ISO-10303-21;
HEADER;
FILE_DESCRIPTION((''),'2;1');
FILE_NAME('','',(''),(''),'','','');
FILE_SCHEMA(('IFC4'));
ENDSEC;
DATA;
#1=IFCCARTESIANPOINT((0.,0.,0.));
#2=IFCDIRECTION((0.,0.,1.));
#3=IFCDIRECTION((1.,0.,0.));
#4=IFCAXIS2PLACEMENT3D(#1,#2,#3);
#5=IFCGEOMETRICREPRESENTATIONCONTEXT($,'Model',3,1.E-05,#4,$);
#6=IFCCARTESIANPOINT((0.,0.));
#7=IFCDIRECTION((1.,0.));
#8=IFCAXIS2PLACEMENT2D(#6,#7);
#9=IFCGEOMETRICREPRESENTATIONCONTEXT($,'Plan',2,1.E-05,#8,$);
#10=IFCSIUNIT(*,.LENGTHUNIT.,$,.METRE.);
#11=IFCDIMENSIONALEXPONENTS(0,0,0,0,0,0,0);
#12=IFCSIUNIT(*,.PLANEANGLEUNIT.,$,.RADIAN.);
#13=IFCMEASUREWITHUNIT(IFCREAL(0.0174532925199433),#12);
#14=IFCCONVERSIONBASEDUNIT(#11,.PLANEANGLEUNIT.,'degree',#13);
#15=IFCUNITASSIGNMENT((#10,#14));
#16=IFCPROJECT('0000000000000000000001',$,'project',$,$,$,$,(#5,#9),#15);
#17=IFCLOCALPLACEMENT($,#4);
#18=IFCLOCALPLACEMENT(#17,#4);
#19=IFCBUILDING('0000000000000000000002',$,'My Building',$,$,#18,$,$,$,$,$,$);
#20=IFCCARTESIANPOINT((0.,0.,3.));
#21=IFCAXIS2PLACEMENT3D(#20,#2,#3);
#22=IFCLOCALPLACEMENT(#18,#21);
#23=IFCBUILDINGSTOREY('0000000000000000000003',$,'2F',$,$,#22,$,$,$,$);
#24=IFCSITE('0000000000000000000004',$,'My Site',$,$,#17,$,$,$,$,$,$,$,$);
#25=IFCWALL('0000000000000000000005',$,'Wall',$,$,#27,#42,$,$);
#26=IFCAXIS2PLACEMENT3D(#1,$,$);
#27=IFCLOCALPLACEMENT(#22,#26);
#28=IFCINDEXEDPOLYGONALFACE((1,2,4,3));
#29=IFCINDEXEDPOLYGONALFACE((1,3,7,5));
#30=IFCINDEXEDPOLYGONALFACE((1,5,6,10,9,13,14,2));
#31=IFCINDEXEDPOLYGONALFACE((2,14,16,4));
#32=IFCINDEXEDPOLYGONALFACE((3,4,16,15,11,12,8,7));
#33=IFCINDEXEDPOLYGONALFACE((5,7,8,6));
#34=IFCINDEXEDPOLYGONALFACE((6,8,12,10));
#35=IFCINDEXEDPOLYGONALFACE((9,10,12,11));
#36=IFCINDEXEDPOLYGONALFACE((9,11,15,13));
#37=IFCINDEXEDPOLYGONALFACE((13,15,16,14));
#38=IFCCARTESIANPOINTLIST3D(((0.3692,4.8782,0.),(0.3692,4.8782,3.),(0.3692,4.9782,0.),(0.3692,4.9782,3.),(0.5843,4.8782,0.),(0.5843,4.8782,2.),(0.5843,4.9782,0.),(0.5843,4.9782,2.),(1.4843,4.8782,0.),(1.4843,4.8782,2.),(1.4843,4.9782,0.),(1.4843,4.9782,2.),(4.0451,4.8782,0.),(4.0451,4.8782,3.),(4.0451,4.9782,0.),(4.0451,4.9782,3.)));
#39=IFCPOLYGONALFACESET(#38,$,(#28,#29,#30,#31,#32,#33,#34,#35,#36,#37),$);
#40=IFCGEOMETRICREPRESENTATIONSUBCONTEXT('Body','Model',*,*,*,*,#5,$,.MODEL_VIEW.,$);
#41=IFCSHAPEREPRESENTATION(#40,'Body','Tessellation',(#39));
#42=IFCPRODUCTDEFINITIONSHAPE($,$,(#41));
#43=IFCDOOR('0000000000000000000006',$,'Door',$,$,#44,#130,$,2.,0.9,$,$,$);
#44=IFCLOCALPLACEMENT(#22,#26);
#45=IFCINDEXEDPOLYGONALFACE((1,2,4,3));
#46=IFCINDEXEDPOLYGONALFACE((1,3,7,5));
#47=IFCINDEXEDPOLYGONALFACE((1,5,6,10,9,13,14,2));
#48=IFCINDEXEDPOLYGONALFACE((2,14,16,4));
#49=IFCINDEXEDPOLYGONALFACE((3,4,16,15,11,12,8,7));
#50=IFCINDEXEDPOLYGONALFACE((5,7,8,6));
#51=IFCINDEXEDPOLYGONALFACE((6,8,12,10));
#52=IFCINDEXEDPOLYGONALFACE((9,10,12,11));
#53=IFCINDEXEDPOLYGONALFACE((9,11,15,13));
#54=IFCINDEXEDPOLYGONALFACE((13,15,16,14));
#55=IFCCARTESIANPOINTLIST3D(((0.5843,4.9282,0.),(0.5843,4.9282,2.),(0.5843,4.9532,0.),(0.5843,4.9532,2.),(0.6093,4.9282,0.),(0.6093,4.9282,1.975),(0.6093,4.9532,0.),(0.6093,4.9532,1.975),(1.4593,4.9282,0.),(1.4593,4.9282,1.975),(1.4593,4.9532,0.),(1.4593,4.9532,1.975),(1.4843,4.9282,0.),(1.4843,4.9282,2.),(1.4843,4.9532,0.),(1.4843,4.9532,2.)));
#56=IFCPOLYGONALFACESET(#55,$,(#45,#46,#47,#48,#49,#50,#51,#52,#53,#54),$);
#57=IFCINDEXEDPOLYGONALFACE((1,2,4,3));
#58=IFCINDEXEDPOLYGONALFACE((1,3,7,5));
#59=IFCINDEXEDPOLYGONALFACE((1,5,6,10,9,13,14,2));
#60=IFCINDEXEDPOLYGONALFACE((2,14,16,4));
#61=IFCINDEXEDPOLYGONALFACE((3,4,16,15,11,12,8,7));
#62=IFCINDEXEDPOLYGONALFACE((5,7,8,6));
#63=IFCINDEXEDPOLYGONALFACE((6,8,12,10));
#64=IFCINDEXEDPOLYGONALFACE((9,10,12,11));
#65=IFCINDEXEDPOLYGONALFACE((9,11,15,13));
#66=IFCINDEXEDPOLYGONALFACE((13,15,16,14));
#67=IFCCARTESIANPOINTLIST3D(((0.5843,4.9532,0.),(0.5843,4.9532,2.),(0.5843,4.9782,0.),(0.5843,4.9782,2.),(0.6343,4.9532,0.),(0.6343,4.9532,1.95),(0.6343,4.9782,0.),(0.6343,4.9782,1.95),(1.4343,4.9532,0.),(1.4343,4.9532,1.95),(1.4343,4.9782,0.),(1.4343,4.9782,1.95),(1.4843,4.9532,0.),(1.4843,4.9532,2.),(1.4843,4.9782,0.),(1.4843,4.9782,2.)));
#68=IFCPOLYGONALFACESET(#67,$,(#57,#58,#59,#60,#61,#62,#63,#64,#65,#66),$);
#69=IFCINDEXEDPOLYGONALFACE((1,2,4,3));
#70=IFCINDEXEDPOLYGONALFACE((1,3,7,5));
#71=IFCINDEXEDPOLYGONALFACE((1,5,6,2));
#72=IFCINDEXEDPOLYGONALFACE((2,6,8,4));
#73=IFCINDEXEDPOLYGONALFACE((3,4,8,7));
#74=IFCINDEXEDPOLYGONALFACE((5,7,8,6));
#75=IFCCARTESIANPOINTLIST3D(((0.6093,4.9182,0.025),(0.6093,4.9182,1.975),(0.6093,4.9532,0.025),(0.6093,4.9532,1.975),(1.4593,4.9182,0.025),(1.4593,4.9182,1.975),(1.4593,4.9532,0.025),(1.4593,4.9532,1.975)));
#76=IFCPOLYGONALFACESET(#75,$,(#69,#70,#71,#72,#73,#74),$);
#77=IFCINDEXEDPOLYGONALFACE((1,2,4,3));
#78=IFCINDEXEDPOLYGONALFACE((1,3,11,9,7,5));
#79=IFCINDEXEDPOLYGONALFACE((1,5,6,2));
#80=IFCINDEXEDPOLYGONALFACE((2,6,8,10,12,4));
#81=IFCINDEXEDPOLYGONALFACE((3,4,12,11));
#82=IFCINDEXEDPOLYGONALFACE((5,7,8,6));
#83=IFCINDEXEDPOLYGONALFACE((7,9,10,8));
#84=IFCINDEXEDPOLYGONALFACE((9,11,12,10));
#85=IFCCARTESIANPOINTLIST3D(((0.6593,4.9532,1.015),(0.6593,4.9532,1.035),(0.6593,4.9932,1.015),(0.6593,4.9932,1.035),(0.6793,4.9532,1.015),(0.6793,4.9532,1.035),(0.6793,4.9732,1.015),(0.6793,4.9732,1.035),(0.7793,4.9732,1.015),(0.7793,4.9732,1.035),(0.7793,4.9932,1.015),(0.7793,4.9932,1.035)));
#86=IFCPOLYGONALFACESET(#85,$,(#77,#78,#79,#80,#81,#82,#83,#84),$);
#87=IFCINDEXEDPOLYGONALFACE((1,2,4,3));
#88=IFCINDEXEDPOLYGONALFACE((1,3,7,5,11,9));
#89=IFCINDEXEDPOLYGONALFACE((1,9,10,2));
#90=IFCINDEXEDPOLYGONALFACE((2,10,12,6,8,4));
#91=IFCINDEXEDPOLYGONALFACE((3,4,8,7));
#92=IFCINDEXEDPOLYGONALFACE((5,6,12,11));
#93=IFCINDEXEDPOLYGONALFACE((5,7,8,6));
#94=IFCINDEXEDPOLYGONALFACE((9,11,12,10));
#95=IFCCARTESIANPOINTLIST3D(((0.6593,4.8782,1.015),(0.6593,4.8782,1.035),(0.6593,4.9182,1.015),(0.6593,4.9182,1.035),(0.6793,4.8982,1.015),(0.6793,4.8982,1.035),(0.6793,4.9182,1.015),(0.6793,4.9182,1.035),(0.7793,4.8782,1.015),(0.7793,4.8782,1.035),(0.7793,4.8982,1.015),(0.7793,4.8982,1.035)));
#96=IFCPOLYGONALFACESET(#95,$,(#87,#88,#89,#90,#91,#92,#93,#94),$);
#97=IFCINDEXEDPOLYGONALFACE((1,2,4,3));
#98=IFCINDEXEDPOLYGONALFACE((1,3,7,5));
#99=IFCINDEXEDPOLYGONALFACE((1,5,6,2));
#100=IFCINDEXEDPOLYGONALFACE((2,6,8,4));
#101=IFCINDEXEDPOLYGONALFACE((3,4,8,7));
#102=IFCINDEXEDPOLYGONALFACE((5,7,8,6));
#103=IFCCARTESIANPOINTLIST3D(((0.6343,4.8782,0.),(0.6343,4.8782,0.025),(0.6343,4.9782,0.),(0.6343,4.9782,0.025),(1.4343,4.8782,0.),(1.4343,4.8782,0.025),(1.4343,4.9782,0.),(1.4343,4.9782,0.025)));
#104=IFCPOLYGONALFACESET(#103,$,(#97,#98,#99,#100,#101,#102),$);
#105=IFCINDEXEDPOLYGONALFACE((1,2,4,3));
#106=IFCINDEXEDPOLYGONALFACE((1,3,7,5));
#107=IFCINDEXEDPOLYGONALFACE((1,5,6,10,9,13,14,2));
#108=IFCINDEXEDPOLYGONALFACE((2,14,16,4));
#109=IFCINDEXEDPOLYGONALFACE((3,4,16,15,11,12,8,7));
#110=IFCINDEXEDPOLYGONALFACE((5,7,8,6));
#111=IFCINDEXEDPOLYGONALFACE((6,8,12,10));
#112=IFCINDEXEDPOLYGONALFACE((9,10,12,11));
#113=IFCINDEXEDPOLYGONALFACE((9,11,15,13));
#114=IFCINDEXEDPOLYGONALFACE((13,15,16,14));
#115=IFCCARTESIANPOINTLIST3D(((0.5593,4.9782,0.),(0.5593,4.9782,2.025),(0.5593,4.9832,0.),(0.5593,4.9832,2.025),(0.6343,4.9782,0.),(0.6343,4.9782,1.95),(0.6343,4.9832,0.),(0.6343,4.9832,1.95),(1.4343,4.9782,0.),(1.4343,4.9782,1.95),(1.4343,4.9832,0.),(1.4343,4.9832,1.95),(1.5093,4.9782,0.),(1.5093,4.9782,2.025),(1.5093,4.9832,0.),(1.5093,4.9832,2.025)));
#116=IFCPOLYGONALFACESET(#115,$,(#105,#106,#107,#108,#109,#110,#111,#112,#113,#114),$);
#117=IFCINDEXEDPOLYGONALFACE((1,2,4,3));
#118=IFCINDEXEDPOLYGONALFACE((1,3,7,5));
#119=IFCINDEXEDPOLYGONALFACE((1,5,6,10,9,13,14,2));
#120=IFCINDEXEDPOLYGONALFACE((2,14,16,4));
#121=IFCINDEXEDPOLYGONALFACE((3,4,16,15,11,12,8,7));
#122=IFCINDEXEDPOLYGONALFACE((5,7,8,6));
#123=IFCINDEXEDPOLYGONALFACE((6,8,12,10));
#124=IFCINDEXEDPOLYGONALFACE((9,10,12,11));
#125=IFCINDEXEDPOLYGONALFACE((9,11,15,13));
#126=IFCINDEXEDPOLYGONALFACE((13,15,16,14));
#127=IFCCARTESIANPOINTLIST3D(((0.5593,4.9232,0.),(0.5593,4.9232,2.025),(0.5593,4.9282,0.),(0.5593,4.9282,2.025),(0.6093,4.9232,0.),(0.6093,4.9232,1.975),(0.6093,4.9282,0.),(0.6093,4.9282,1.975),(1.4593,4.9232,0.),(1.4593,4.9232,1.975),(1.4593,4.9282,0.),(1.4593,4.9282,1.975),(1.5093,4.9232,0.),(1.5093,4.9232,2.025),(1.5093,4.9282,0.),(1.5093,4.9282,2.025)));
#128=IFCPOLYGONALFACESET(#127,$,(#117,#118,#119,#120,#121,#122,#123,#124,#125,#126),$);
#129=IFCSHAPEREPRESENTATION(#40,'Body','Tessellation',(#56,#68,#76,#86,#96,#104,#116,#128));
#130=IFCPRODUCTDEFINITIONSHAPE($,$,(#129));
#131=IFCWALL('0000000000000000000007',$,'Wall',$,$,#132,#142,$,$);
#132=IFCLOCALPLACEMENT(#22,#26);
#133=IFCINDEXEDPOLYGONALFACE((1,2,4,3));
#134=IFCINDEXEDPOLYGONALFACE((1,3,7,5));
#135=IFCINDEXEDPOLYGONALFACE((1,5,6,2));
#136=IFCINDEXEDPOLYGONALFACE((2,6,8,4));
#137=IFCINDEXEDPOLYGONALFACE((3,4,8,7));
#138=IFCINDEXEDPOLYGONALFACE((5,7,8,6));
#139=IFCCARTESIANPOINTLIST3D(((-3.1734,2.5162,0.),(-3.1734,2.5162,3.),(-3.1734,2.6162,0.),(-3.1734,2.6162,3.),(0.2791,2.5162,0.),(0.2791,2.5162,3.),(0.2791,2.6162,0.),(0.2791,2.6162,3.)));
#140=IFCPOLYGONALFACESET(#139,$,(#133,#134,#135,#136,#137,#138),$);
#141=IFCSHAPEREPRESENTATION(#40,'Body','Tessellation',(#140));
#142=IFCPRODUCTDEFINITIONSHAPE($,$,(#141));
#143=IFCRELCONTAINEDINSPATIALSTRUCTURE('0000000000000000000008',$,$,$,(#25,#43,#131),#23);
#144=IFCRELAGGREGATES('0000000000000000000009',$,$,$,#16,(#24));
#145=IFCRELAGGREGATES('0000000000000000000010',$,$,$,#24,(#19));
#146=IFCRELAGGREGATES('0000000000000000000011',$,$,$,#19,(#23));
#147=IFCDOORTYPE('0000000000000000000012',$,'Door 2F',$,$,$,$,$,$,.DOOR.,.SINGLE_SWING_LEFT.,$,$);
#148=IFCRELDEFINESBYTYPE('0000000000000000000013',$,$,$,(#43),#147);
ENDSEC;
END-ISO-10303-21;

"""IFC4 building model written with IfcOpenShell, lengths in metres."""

from ifc_helpers import new_model, entity, si_unit, converted_unit, frame, origin_with_axes, origin_2d_with_axis, place, context, subcontext, project, spatial, line, indexed_curve, outline, extrude, shape, source, transform, mapped, type_object, type_shapes, element, fill, save


model = new_model("IFC4")

# Units and contexts
model_context = context("Model", 3, precision=1e-05, world=origin_with_axes())
plan_context = context("Plan", 2, precision=1e-05, world=origin_2d_with_axis())
body_context_1 = subcontext(model_context, "Body", "Model", "MODEL_VIEW")
body_context_2 = subcontext(plan_context, "Body", "Plan", "PLAN_VIEW")
ifc_project = project(units=[si_unit("LENGTHUNIT", "METRE"), converted_unit("PLANEANGLEUNIT", "degree", entity("IfcReal", 0.0174532925199433), si_unit("PLANEANGLEUNIT", "RADIAN"), dimensions=[0, 0, 0, 0, 0, 0, 0])], contexts=[model_context, plan_context])

# Site, building, storey
site_placement = place(None, origin_with_axes())
site = spatial("IfcSite", under=ifc_project, at=site_placement, Name="My Site")
building_placement = place(site_placement, origin_with_axes())
building = spatial("IfcBuilding", under=site, at=building_placement, Name="My Building")
storey_placement = place(building_placement, frame((0.0, 0.0, 3.0), z_axis=(0.0, 0.0, 1.0), x_axis=(1.0, 0.0, 0.0)))
storey = spatial("IfcBuildingStorey", under=building, at=storey_placement, Name="2F")

# Shared definitions
shared_shape_1 = source(origin_with_axes(), body_context_1, "Body", "SweptSolid", [
    extrude(outline(indexed_curve([(0.0, 0.0), (0.9, 0.0), (0.9, 2.0), (0.0, 2.0)], segments=[line(1, 2, 3, 4, 1)])), frame((0.0, -0.6, 0.0), z_axis=(0.0, -1.0, 0.0), x_axis=(1.0, 0.0, 0.0)), (0.0, 0.0, -1.0), 1.2),
])
door_type = type_object("IfcDoorType", Name="Door 2F", OperationType="SINGLE_SWING_LEFT", PredefinedType="DOOR")
shared_shape_2 = source(origin_with_axes(), body_context_1, "Body", "SweptSolid", [
    extrude(outline(indexed_curve([(0.0, 0.0), (0.0, 2.0), (0.9, 2.0), (0.9, 0.0), (0.875, 0.0), (0.875, 1.975), (0.025, 1.975), (0.025, 0.0)], segments=[line(1, 2, 3, 4, 5, 6, 7, 8, 1)])), frame((0.0, 0.025, 0.0), z_axis=(0.0, -1.0, 0.0), x_axis=(1.0, 0.0, 0.0)), (0.0, 0.0, -1.0), 0.025),
    extrude(outline(indexed_curve([(0.0, 0.0), (0.0, 2.0), (0.9, 2.0), (0.9, 0.0), (0.85, 0.0), (0.85, 1.95), (0.05, 1.95), (0.05, 0.0)], segments=[line(1, 2, 3, 4, 5, 6, 7, 8, 1)])), frame((0.0, 0.0, 0.0), z_axis=(0.0, -1.0, 0.0), x_axis=(1.0, 0.0, 0.0)), (0.0, 0.0, -1.0), 0.025),
    extrude(outline(indexed_curve([(0.0, 0.0), (0.85, 0.0), (0.85, 0.035), (0.0, 0.035)], segments=[line(1, 2, 3, 4, 1)])), frame((0.025, 0.025, 0.025), z_axis=(0.0, 0.0, 1.0), x_axis=(1.0, 0.0, 0.0)), (0.0, 0.0, 1.0), 1.95),
    extrude(outline(indexed_curve([(0.0, 0.0), (0.0, -0.04), (-0.12, -0.04), (-0.12, -0.02), (-0.02, -0.02), (-0.02, 0.0)], segments=[line(1, 2, 3, 4, 5, 6, 1)])), frame((0.825, 0.025, 1.015), z_axis=(0.0, 0.0, 1.0), x_axis=(1.0, 0.0, 0.0)), (0.0, 0.0, 1.0), 0.02),
    extrude(outline(indexed_curve([(0.0, 0.0), (0.0, 0.04), (-0.12, 0.04), (-0.12, 0.02), (-0.02, 0.02), (-0.02, 0.0)], segments=[line(1, 2, 3, 4, 5, 6, 1)])), frame((0.825, 0.06, 1.015), z_axis=(0.0, 0.0, 1.0), x_axis=(1.0, 0.0, 0.0)), (0.0, 0.0, 1.0), 0.02),
    extrude(outline(indexed_curve([(0.0, 0.0), (0.8, 0.0), (0.8, 0.1), (0.0, 0.1)], segments=[line(1, 2, 3, 4, 1)])), frame((0.05, 0.0, 0.0), z_axis=(0.0, 0.0, 1.0), x_axis=(1.0, 0.0, 0.0)), (0.0, 0.0, 1.0), 0.025),
    extrude(outline(indexed_curve([(0.0, 0.0), (0.0, 2.025), (0.95, 2.025), (0.95, 0.0), (0.875, 0.0), (0.875, 1.95), (0.075, 1.95), (0.075, 0.0)], segments=[line(1, 2, 3, 4, 5, 6, 7, 8, 1)])), frame((-0.025, -0.005, 0.0), z_axis=(0.0, -1.0, 0.0), x_axis=(1.0, 0.0, 0.0)), (0.0, 0.0, -1.0), 0.005),
    extrude(outline(indexed_curve([(0.0, 0.0), (0.0, 2.025), (0.95, 2.025), (0.95, 0.0), (0.9, 0.0), (0.9, 1.975), (0.05, 1.975), (0.05, 0.0)], segments=[line(1, 2, 3, 4, 5, 6, 7, 8, 1)])), frame((-0.025, 0.05, 0.0), z_axis=(0.0, -1.0, 0.0), x_axis=(1.0, 0.0, 0.0)), (0.0, 0.0, -1.0), 0.005),
])
shared_shape_3 = source(origin_with_axes(), body_context_2, "Body", "Curve2D", [
    entity("IfcIndexedPolyCurve", entity("IfcCartesianPointList2D", [[0.0, 0.0], [0.0, 0.05], [0.025, 0.05], [0.025, 0.025], [0.05, 0.025], [0.05, 0.0]]), [entity("IfcLineIndex", [1, 2, 3, 4, 5, 6, 1])]),
    entity("IfcIndexedPolyCurve", entity("IfcCartesianPointList2D", [[0.9, 0.0], [0.9, 0.05], [0.875, 0.05], [0.875, 0.025], [0.85, 0.025], [0.85, 0.0]]), [entity("IfcLineIndex", [1, 2, 3, 4, 5, 6, 1])]),
    entity("IfcTrimmedCurve", entity("IfcEllipse", entity("IfcAxis2Placement2D", entity("IfcCartesianPoint", [0.06, 0.05]), entity("IfcDirection", [1.0, 0.0])), 0.815, 0.85), [entity("IfcCartesianPoint", [0.875, 0.05])], [entity("IfcCartesianPoint", [0.06, 0.9])], True, "CARTESIAN"),
    entity("IfcIndexedPolyCurve", entity("IfcCartesianPointList2D", [[0.025, 0.05], [0.06, 0.05], [0.06, 0.9], [0.025, 0.9]]), [entity("IfcLineIndex", [1, 2, 3, 4, 1])]),
])
type_shapes(door_type, [shared_shape_2, shared_shape_3])

# Wall, opening, door
wall_1_placement = place(storey_placement, frame((4.0451, 4.9782, 0.0), z_axis=(0.0, 0.0, 1.0), x_axis=(-1.0, 0.0, 0.0)))
wall_1 = element("IfcWall", 1, at=wall_1_placement, inside=storey, Name="Wall", context=body_context_1, shape_type="SweptSolid", body=[
    extrude(outline(indexed_curve([(0.0, 0.0), (0.0, 0.1), (3.6759, 0.1), (3.6759, 0.0)], segments=[line(1, 2, 3, 4, 1)])), origin_with_axes(), (0.0, 0.0, 1.0), 3.0),
])
opening_1_placement = place(wall_1_placement, frame((2.5609, 0.0, 0.0), z_axis=(0.0, 0.0, 1.0), x_axis=(1.0, 0.0, 0.0)))
opening_1 = element("IfcOpeningElement", 2, at=opening_1_placement, cuts=wall_1, PredefinedType="OPENING", context=body_context_1, shape_type="MappedRepresentation", body=[
    mapped(shared_shape_1, transform((0.0, 0.0, 0.0), x_axis=(1.0, 0.0, 0.0), y_axis=(0.0, 1.0, 0.0), z_axis=(0.0, 0.0, 1.0), scale=1.0)),
])
door_1_placement = place(opening_1_placement, frame((0.0, 0.0, 0.0), z_axis=(0.0, 0.0, 1.0), x_axis=(1.0, 0.0, 0.0)))
door_1 = element("IfcDoor", 3, at=door_1_placement, inside=storey, type_object=door_type, Name="Door", OverallHeight=2.0, OverallWidth=0.9, shapes=[
    shape(body_context_1, "Body", "MappedRepresentation", [mapped(shared_shape_2, transform((0.0, 0.0, 0.0), x_axis=(1.0, 0.0, 0.0), y_axis=(0.0, 1.0, 0.0), z_axis=(0.0, 0.0, 1.0), scale=1.0))]),
    shape(body_context_2, "Body", "MappedRepresentation", [mapped(shared_shape_3, transform((0.0, 0.0, 0.0), x_axis=(1.0, 0.0, 0.0), y_axis=(0.0, 1.0, 0.0), z_axis=(0.0, 0.0, 1.0), scale=1.0))]),
])
fill(opening_1, door_1)

# Wall
wall_2_placement = place(storey_placement, frame((0.2791, 2.6162, 0.0), z_axis=(0.0, 0.0, 1.0), x_axis=(-1.0, 0.0, 0.0)))
element("IfcWall", 4, at=wall_2_placement, inside=storey, Name="Wall", context=body_context_1, shape_type="SweptSolid", body=[
    extrude(outline(indexed_curve([(0.0, 0.0), (0.0, 0.1), (3.4525, 0.1), (3.4525, 0.0)], segments=[line(1, 2, 3, 4, 1)])), origin_with_axes(), (0.0, 0.0, 1.0), 3.0),
])

save(model, "model.ifc")
